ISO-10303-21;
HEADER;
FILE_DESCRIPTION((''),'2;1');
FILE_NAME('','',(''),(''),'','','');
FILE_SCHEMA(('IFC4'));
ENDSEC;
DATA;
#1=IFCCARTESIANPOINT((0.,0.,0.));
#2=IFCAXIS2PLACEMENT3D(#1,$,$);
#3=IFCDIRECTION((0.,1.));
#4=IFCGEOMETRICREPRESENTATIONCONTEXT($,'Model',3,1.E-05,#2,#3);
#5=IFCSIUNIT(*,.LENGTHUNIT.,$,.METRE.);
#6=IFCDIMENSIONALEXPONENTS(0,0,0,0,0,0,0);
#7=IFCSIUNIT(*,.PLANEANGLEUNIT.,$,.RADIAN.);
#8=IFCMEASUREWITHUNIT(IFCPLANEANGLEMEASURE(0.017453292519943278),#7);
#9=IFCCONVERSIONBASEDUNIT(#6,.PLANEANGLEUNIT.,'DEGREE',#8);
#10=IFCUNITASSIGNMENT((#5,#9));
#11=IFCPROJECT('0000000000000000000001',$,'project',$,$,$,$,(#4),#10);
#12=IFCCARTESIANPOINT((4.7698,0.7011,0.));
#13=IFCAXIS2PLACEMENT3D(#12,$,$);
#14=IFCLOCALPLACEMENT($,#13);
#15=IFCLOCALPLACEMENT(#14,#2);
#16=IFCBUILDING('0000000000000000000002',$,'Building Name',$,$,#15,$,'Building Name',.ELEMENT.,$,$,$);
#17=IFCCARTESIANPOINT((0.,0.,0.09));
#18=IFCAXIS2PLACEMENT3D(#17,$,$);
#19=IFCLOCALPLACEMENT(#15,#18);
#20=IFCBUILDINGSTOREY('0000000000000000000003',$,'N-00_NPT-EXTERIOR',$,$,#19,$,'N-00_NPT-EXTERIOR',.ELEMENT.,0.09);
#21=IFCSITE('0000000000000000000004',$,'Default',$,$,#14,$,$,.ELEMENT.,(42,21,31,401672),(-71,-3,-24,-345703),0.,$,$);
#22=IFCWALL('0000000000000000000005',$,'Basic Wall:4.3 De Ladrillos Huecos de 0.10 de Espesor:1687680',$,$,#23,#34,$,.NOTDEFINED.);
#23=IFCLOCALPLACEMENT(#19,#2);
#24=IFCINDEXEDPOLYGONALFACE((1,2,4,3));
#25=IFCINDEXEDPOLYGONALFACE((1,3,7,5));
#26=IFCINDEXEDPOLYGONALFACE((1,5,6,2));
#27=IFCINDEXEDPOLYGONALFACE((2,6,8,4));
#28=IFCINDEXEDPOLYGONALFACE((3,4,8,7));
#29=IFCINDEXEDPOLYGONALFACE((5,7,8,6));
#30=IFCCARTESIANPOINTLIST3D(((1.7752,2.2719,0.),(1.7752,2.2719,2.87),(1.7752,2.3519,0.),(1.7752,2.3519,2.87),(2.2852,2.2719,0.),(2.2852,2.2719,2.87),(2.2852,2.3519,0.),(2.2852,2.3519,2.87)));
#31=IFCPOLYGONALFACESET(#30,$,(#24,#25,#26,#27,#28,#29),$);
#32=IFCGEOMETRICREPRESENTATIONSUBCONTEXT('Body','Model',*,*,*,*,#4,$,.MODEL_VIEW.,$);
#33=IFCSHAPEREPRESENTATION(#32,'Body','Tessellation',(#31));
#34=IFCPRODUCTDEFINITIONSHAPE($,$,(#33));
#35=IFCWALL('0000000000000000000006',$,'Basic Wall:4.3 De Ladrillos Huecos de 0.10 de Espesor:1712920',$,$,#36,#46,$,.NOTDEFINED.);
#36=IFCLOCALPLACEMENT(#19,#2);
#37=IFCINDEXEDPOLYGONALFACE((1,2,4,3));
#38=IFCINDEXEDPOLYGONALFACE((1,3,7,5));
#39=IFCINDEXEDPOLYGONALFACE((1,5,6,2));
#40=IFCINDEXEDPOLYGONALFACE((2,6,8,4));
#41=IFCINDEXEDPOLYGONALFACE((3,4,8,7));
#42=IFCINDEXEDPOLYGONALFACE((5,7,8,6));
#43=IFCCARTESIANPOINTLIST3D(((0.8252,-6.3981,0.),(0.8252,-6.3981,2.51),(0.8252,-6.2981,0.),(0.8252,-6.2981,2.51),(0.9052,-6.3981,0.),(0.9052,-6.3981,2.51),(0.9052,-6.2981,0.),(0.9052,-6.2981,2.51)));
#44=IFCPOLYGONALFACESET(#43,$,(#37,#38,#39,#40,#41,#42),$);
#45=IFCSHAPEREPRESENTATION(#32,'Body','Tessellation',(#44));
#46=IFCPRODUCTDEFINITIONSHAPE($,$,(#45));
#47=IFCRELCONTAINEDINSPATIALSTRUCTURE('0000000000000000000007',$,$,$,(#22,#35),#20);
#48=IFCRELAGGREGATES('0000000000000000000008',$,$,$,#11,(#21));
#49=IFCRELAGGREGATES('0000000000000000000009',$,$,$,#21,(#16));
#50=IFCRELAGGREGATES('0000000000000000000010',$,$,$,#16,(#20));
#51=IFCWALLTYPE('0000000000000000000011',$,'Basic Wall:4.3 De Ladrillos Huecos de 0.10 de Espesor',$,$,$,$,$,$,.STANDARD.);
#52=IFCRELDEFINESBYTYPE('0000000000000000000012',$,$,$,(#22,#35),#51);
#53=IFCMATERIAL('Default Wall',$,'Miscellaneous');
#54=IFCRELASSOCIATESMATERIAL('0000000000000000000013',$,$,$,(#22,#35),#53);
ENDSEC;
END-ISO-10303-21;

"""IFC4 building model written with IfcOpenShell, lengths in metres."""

from ifc_helpers import new_model, entity, si_unit, converted_unit, direction, frame, origin, place, context, subcontext, project, spatial, indexed_curve, outline, extrude, material, type_object, element, save


model = new_model("IFC4")

# Units and contexts
model_context = context("Model", 3, precision=1e-05, world=origin(), true_north=direction((0.0, 1.0)))
body_context = subcontext(model_context, "Body", "Model", "MODEL_VIEW")
ifc_project = project(units=[si_unit("LENGTHUNIT", "METRE"), converted_unit("PLANEANGLEUNIT", "DEGREE", entity("IfcPlaneAngleMeasure", 0.017453292519943278), si_unit("PLANEANGLEUNIT", "RADIAN"), dimensions=[0, 0, 0, 0, 0, 0, 0])], contexts=[model_context])

# Site, building, storey
site_placement = place(None, frame((4.7698, 0.7011, 0.0)))
site = spatial("IfcSite", under=ifc_project, at=site_placement, Name="Default", CompositionType="ELEMENT", RefLatitude=(42, 21, 31, 401672), RefLongitude=(-71, -3, -24, -345703), RefElevation=0.0)
building_placement = place(site_placement, origin())
building = spatial("IfcBuilding", under=site, at=building_placement, Name="Building Name", LongName="Building Name", CompositionType="ELEMENT")
storey_placement = place(building_placement, frame((0.0, 0.0, 0.09)))
storey = spatial("IfcBuildingStorey", under=building, at=storey_placement, Name="N-00_NPT-EXTERIOR", LongName="N-00_NPT-EXTERIOR", CompositionType="ELEMENT", Elevation=0.09)

# Walls
ifc_material_1 = material(Name="Default Wall", Category="Miscellaneous")
wall_type_1 = type_object("IfcWallType", Name="Basic Wall:4.3 De Ladrillos Huecos de 0.10 de Espesor", PredefinedType="STANDARD")
wall_1_placement = place(storey_placement, frame((1.7752, 2.3119, 0.0)))
element("IfcWall", 1, at=wall_1_placement, inside=storey, type_object=wall_type_1, material=ifc_material_1, Name="Basic Wall:4.3 De Ladrillos Huecos de 0.10 de Espesor:1687680", PredefinedType="NOTDEFINED", context=body_context, shape_type="SweptSolid", body=[
    extrude(outline(indexed_curve([(0.51, 0.04), (0.0, 0.04), (0.0, -0.04), (0.51, -0.04), (0.51, 0.04)], self_intersect=False)), origin(), (0.0, 0.0, 1.0), 2.87),
])
wall_2_placement = place(storey_placement, frame((0.8652, -6.2981, 0.0), z_axis=(0.0, 0.0, 1.0), x_axis=(0.0, -1.0, 0.0)))
element("IfcWall", 2, at=wall_2_placement, inside=storey, type_object=wall_type_1, material=ifc_material_1, Name="Basic Wall:4.3 De Ladrillos Huecos de 0.10 de Espesor:1712920", PredefinedType="NOTDEFINED", context=body_context, shape_type="SweptSolid", body=[
    extrude(outline(indexed_curve([(0.1, 0.04), (0.0, 0.04), (0.0, -0.04), (0.1, -0.04), (0.1, 0.04)], self_intersect=False)), origin(), (0.0, 0.0, 1.0), 2.51),
])

save(model, "model.ifc")
